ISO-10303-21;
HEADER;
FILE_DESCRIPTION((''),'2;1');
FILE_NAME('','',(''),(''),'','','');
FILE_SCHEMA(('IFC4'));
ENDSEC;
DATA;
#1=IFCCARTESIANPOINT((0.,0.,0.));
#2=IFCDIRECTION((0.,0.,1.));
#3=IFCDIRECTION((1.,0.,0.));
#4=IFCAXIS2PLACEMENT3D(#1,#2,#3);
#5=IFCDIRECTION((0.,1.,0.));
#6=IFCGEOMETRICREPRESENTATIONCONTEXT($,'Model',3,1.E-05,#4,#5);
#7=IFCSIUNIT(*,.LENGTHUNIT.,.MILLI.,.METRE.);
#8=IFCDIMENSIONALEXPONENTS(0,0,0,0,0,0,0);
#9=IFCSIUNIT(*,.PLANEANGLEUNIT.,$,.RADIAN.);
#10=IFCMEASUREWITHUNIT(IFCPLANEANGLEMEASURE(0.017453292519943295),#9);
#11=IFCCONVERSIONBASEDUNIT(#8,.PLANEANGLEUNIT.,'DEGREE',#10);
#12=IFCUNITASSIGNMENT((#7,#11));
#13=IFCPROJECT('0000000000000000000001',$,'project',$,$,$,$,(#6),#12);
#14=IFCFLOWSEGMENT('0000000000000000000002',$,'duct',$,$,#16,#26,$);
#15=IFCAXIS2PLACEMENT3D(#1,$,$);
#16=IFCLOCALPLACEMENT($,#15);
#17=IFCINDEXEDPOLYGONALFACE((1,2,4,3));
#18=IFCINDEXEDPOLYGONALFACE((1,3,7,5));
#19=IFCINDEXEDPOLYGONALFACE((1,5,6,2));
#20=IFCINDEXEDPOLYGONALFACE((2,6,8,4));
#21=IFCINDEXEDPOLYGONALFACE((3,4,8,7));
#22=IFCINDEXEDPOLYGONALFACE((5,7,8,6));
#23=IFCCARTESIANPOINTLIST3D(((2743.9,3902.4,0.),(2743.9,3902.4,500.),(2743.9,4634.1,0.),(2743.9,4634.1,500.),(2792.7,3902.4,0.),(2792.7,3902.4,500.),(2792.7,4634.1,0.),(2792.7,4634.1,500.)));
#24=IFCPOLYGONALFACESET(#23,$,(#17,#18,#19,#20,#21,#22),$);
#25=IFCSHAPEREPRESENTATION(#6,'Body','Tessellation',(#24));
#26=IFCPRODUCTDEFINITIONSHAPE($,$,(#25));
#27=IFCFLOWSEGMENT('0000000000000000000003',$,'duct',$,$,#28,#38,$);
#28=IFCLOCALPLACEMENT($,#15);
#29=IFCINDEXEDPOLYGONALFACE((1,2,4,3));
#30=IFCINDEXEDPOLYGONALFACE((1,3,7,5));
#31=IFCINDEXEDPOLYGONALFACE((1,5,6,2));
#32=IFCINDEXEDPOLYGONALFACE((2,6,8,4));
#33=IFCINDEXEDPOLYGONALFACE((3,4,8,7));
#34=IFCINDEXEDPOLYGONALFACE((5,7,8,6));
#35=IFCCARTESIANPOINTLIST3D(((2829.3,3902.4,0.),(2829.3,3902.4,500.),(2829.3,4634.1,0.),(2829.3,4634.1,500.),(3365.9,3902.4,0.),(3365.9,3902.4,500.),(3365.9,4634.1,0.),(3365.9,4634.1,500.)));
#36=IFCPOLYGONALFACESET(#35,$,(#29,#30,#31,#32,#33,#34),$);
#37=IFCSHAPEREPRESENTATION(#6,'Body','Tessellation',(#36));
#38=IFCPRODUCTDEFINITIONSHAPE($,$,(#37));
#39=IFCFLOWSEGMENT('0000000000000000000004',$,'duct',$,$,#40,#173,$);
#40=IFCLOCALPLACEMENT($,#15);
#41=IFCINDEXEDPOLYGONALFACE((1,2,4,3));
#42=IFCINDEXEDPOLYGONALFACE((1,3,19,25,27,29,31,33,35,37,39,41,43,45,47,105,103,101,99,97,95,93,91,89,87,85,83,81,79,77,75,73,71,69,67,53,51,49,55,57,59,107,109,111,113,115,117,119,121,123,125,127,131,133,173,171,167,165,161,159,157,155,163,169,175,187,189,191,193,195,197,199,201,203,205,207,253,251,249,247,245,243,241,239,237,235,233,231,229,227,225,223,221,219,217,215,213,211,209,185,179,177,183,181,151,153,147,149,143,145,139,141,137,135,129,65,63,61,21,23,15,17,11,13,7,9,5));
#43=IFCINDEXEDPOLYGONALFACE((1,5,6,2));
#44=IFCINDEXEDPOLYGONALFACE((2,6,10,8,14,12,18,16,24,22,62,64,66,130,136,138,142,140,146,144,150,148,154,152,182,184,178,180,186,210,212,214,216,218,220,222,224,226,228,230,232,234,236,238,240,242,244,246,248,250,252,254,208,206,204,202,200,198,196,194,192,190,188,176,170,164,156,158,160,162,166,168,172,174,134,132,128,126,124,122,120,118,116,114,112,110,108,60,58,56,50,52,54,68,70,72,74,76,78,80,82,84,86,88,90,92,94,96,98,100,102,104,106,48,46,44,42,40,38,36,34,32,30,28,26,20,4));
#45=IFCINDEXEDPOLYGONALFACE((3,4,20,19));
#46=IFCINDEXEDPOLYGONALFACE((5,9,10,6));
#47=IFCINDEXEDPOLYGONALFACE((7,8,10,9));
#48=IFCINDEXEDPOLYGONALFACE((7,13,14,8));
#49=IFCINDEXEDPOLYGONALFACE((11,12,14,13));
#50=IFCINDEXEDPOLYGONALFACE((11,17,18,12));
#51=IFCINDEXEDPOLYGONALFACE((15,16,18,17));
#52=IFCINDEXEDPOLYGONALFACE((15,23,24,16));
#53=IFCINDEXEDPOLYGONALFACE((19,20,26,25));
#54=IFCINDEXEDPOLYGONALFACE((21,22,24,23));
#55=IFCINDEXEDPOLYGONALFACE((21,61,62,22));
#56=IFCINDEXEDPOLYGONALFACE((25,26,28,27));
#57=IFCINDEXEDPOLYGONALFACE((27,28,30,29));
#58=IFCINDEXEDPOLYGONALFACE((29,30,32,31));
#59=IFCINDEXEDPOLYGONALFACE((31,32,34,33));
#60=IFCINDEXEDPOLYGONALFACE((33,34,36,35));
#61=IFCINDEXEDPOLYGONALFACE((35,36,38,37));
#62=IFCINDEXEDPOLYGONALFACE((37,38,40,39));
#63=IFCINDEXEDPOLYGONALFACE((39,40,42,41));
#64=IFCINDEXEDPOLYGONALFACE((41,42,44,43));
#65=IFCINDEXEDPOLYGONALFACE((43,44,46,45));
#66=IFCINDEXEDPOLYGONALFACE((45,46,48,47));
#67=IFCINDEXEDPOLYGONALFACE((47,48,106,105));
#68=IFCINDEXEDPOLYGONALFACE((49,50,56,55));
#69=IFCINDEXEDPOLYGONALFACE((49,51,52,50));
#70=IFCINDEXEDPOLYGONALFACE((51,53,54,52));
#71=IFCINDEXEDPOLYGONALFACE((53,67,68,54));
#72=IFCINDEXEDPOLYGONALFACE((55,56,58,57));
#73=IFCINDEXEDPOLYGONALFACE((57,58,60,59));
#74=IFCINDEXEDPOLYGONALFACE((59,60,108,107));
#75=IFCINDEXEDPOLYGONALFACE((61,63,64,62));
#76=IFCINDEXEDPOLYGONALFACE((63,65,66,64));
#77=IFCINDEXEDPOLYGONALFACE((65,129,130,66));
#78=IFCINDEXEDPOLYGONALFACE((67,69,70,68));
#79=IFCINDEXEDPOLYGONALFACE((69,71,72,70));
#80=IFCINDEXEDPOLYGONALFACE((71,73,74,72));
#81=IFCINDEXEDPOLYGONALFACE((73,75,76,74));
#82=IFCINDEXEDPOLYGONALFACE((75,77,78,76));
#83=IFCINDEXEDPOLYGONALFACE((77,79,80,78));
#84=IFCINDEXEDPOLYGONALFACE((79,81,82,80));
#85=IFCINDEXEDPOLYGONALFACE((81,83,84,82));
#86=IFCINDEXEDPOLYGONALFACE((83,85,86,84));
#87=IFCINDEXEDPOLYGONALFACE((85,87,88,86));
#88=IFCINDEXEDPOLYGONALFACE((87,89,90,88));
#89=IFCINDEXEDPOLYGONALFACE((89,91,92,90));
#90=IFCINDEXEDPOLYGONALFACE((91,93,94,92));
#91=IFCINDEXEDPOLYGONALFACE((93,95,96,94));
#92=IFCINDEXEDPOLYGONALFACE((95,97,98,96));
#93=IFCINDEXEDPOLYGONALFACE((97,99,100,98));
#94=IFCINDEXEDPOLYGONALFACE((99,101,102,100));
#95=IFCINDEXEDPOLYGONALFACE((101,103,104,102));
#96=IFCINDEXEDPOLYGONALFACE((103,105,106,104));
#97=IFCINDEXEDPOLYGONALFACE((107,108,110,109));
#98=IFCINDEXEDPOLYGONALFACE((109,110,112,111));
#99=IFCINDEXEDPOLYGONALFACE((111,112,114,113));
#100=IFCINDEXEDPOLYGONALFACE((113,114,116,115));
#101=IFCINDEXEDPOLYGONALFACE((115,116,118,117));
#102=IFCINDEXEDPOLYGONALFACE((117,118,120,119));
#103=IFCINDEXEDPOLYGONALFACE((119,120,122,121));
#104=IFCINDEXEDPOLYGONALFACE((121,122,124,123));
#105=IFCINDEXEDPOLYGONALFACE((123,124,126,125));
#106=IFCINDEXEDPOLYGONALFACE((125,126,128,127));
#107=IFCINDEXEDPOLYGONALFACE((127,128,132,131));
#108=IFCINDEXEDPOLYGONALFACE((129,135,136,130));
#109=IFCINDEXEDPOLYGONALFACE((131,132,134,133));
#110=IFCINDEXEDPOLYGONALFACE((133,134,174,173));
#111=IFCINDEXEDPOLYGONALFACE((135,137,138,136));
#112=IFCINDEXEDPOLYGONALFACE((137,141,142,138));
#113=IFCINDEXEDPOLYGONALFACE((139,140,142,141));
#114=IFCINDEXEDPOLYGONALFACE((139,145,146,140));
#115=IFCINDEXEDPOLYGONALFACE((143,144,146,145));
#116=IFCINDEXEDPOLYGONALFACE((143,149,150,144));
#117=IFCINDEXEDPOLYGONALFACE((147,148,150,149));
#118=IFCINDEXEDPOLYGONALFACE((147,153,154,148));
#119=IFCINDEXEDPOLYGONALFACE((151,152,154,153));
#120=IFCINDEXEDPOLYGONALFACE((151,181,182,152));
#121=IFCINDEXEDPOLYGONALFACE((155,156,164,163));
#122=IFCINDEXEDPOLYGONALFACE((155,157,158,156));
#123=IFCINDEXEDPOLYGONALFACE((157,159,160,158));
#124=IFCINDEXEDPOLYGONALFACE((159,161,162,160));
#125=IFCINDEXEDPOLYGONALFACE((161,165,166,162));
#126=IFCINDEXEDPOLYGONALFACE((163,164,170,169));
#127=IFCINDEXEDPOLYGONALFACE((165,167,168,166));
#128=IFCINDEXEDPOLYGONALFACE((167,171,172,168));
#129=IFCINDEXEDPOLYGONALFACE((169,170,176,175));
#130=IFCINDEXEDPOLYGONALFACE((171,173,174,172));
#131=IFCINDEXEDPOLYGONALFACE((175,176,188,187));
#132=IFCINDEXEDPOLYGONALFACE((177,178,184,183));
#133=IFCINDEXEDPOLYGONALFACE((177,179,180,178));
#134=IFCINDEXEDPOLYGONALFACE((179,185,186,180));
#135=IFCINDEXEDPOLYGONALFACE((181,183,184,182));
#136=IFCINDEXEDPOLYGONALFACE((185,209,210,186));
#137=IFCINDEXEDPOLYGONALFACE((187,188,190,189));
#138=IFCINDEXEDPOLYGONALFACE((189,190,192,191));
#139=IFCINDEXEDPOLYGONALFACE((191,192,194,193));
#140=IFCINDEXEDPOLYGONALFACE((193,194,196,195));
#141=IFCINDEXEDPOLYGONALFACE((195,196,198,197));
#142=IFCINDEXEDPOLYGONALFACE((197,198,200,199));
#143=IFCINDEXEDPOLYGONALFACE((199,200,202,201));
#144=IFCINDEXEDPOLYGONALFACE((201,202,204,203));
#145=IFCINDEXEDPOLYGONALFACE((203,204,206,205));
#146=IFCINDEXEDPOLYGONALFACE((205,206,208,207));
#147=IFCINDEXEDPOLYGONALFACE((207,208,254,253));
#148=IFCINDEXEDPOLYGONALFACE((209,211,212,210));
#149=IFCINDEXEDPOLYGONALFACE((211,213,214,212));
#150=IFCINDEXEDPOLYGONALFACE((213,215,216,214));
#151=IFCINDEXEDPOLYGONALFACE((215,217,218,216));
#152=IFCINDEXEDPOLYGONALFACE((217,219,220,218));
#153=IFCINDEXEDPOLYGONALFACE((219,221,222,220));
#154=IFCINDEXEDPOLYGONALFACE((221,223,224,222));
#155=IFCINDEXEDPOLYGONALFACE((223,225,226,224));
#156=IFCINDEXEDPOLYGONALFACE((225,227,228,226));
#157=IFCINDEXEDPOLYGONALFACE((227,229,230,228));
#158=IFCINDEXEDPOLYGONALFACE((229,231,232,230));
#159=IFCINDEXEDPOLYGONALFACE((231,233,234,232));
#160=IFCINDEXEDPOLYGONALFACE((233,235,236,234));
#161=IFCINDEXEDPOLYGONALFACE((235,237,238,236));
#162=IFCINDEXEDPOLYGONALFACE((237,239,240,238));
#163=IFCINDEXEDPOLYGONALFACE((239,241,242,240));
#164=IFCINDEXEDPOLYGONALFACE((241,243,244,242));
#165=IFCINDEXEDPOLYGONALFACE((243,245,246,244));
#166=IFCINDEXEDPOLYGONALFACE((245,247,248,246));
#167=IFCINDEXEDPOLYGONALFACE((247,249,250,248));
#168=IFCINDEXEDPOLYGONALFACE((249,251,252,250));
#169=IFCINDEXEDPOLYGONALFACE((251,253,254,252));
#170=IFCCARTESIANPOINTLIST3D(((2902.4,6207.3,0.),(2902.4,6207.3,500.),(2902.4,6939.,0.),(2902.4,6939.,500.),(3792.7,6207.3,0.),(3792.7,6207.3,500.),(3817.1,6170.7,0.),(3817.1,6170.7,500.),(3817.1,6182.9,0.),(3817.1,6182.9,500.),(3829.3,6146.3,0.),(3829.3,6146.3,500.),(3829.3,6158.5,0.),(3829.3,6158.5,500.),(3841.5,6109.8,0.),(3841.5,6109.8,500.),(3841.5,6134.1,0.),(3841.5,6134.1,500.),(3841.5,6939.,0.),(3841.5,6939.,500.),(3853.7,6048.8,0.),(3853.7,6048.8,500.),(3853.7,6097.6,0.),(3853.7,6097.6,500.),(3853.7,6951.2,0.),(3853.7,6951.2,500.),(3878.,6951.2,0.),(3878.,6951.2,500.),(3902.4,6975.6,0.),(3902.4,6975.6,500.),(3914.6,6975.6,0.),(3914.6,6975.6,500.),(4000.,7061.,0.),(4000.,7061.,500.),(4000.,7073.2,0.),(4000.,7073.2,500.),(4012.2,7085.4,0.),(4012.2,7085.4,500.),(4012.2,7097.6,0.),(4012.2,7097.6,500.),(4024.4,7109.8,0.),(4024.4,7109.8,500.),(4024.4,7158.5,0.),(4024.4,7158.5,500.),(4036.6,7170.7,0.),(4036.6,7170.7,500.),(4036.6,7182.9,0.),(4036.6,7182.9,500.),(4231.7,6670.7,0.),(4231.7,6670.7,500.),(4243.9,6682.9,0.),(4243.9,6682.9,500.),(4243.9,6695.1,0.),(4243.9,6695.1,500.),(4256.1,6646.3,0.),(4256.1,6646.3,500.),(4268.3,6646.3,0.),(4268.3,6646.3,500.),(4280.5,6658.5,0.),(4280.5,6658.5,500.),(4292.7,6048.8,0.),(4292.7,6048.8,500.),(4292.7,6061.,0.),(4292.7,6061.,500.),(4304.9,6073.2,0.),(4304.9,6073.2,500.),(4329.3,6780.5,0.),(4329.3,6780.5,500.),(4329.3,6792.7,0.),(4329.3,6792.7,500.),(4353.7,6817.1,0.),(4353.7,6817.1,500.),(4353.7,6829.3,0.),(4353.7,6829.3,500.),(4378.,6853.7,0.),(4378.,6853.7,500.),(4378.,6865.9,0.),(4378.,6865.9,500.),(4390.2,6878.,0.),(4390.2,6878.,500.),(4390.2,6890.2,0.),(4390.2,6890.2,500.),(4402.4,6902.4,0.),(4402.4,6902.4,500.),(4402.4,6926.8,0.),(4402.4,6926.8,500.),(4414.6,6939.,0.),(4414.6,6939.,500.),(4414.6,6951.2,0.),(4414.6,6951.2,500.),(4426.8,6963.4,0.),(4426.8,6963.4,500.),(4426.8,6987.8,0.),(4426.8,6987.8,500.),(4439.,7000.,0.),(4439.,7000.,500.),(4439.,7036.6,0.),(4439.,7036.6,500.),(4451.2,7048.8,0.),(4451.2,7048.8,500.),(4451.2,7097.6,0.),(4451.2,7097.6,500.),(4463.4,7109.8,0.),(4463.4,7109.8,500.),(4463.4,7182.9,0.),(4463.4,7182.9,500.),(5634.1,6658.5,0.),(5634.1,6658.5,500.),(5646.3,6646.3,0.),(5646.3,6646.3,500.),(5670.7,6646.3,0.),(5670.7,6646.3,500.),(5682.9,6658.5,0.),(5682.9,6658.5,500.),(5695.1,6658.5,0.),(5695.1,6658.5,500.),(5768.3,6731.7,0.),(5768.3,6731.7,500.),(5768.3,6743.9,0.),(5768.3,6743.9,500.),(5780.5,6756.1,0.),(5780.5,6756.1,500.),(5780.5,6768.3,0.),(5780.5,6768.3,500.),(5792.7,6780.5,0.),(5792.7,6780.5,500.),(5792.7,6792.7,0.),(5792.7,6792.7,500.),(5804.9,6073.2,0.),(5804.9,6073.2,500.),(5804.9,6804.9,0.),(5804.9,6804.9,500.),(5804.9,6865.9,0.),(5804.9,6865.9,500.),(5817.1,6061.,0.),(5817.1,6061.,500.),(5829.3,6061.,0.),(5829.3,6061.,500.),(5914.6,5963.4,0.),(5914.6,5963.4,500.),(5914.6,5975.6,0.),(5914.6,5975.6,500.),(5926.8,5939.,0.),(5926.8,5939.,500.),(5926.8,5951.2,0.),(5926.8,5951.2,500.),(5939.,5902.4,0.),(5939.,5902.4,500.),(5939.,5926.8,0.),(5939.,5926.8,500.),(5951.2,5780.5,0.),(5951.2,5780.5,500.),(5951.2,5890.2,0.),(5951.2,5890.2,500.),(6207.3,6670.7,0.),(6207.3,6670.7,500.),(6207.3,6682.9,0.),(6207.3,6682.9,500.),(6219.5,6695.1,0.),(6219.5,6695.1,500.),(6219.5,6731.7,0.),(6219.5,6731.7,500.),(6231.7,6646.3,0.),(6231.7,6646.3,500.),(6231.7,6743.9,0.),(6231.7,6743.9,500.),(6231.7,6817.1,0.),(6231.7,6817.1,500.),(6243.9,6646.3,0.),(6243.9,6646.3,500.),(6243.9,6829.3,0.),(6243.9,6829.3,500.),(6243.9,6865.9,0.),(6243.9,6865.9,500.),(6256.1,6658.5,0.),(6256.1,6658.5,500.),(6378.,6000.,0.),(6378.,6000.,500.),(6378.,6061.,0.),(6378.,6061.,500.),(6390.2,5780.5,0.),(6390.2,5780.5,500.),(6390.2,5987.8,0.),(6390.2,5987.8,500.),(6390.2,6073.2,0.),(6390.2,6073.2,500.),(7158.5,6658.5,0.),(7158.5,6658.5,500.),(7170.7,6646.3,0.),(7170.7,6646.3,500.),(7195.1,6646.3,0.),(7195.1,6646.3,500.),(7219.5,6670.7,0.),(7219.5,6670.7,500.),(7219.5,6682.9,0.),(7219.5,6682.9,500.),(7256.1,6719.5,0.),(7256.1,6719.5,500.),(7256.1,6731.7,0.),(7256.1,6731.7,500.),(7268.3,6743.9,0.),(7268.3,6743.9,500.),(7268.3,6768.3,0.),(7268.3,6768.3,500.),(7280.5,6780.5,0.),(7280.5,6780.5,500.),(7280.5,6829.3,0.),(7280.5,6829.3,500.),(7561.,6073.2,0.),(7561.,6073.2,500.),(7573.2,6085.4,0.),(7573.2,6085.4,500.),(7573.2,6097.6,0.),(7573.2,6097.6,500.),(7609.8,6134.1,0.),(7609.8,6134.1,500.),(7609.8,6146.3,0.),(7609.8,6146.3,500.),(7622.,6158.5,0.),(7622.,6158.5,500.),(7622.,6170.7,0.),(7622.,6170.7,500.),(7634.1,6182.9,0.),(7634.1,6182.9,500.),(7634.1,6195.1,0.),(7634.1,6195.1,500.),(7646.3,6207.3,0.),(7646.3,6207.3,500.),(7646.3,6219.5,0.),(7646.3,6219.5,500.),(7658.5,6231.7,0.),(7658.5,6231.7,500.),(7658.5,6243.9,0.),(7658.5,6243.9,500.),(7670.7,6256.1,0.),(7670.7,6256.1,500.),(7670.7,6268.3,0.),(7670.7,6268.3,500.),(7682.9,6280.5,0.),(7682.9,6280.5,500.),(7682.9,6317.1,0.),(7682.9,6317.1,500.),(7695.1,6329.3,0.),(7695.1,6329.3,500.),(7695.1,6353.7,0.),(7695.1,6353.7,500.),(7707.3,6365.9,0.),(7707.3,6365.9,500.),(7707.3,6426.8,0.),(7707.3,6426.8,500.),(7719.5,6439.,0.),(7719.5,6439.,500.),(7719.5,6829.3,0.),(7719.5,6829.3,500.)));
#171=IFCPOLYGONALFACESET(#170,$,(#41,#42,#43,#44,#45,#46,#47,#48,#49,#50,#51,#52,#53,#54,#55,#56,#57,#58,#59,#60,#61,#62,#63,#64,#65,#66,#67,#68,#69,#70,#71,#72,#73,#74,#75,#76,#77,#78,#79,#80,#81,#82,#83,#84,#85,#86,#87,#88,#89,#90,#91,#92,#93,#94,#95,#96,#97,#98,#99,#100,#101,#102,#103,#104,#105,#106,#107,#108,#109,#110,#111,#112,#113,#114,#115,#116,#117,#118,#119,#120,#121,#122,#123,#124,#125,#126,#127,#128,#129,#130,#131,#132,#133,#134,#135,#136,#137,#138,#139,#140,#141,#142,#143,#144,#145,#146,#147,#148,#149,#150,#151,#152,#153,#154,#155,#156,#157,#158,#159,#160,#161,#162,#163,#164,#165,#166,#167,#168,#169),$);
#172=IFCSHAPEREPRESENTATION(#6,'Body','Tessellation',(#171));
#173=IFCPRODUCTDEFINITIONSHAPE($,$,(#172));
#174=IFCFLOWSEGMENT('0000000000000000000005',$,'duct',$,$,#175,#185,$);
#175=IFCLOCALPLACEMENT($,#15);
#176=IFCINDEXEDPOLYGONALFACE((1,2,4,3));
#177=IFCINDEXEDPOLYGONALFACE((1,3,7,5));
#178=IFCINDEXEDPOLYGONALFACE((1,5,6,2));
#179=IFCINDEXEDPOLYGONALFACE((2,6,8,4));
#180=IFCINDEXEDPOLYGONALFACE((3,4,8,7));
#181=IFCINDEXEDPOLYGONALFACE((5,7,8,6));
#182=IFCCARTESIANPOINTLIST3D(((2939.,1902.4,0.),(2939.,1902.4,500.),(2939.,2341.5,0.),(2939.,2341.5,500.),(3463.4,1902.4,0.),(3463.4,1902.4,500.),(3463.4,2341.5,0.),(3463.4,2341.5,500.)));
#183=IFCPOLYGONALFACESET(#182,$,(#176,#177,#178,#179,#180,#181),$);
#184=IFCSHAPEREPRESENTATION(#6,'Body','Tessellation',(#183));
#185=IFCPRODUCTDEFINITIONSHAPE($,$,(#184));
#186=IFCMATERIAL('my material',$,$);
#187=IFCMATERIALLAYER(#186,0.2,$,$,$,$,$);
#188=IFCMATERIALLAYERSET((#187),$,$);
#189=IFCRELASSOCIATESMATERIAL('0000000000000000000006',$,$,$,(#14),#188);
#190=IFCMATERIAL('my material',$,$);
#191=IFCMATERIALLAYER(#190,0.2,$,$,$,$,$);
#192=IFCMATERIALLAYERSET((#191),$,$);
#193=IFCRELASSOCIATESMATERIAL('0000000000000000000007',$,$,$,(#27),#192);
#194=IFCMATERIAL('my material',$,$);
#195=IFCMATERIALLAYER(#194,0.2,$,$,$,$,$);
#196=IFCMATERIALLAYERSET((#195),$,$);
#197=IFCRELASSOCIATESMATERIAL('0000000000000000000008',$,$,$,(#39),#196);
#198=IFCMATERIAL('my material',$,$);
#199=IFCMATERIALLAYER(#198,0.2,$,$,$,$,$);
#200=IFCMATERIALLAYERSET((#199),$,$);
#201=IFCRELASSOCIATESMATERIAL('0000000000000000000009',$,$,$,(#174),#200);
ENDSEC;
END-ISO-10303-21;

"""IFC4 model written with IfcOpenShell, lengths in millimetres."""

from ifc_helpers import new_model, entity, si_unit, converted_unit, direction, origin_with_axes, place, context, project, polyline, outline, extrude, material, layer, layer_set, layer_usage, element, save


model = new_model("IFC4")

# Units and contexts
model_context = context("Model", 3, precision=1e-05, world=origin_with_axes(), true_north=direction((0.0, 1.0, 0.0)))
ifc_project = project(units=[si_unit("LENGTHUNIT", "METRE", prefix="MILLI"), converted_unit("PLANEANGLEUNIT", "DEGREE", entity("IfcPlaneAngleMeasure", 0.017453292519943295), si_unit("PLANEANGLEUNIT", "RADIAN"), dimensions=[0, 0, 0, 0, 0, 0, 0])], contexts=[model_context])

# Flow segments
ifc_material_1 = material(Name="my material")
ifc_layer_1 = layer(ifc_material_1, 0.2)
ifc_layer_set_1 = layer_set([ifc_layer_1])
ifc_layer_usage_1 = layer_usage(ifc_layer_set_1, "AXIS2", "POSITIVE", -0.1)
flow_segment_1_placement = place(None, origin_with_axes())
element("IfcFlowSegment", 1, at=flow_segment_1_placement, material=ifc_layer_usage_1, Name="duct", context=model_context, shape_type="SweptSolid", body=[
    extrude(outline(polyline([(2743.9, 3902.4), (2792.7, 3902.4), (2792.7, 4634.1), (2743.9, 4634.1), (2743.9, 3902.4)])), origin_with_axes(), (0.0, 0.0, 1.0), 500.0),
])
ifc_material_2 = material(Name="my material")
ifc_layer_2 = layer(ifc_material_2, 0.2)
ifc_layer_set_2 = layer_set([ifc_layer_2])
ifc_layer_usage_2 = layer_usage(ifc_layer_set_2, "AXIS2", "POSITIVE", -0.1)
flow_segment_2_placement = place(None, origin_with_axes())
element("IfcFlowSegment", 2, at=flow_segment_2_placement, material=ifc_layer_usage_2, Name="duct", context=model_context, shape_type="SweptSolid", body=[
    extrude(outline(polyline([(2829.3, 3902.4), (3365.9, 3902.4), (3365.9, 4634.1), (2829.3, 4634.1), (2829.3, 3902.4)])), origin_with_axes(), (0.0, 0.0, 1.0), 500.0),
])
ifc_material_3 = material(Name="my material")
ifc_layer_3 = layer(ifc_material_3, 0.2)
ifc_layer_set_3 = layer_set([ifc_layer_3])
ifc_layer_usage_3 = layer_usage(ifc_layer_set_3, "AXIS2", "POSITIVE", -0.1)
flow_segment_3_placement = place(None, origin_with_axes())
element("IfcFlowSegment", 3, at=flow_segment_3_placement, material=ifc_layer_usage_3, Name="duct", context=model_context, shape_type="SweptSolid", body=[
    extrude(outline(polyline([(2902.4, 6207.3), (3792.7, 6207.3), (3817.1, 6182.9), (3817.1, 6170.7), (3829.3, 6158.5), (3829.3, 6146.3), (3841.5, 6134.1), (3841.5, 6109.8), (3853.7, 6097.6), (3853.7, 6048.8), (4292.7, 6048.8), (4292.7, 6061.0), (4304.9, 6073.2), (5804.9, 6073.2), (5817.1, 6061.0), (5829.3, 6061.0), (5914.6, 5975.6), (5914.6, 5963.4), (5926.8, 5951.2), (5926.8, 5939.0), (5939.0, 5926.8), (5939.0, 5902.4), (5951.2, 5890.2), (5951.2, 5780.5), (6390.2, 5780.5), (6390.2, 5987.8), (6378.0, 6000.0), (6378.0, 6061.0), (6390.2, 6073.2), (7561.0, 6073.2), (7573.2, 6085.4), (7573.2, 6097.6), (7609.8, 6134.1), (7609.8, 6146.3), (7622.0, 6158.5), (7622.0, 6170.7), (7634.1, 6182.9), (7634.1, 6195.1), (7646.3, 6207.3), (7646.3, 6219.5), (7658.5, 6231.7), (7658.5, 6243.9), (7670.7, 6256.1), (7670.7, 6268.3), (7682.9, 6280.5), (7682.9, 6317.1), (7695.1, 6329.3), (7695.1, 6353.7), (7707.3, 6365.9), (7707.3, 6426.8), (7719.5, 6439.0), (7719.5, 6829.3), (7280.5, 6829.3), (7280.5, 6780.5), (7268.3, 6768.3), (7268.3, 6743.9), (7256.1, 6731.7), (7256.1, 6719.5), (7219.5, 6682.9), (7219.5, 6670.7), (7195.1, 6646.3), (7170.7, 6646.3), (7158.5, 6658.5), (6256.1, 6658.5), (6243.9, 6646.3), (6231.7, 6646.3), (6207.3, 6670.7), (6207.3, 6682.9), (6219.5, 6695.1), (6219.5, 6731.7), (6231.7, 6743.9), (6231.7, 6817.1), (6243.9, 6829.3), (6243.9, 6865.9), (5804.9, 6865.9), (5804.9, 6804.9), (5792.7, 6792.7), (5792.7, 6780.5), (5780.5, 6768.3), (5780.5, 6756.1), (5768.3, 6743.9), (5768.3, 6731.7), (5695.1, 6658.5), (5682.9, 6658.5), (5670.7, 6646.3), (5646.3, 6646.3), (5634.1, 6658.5), (4280.5, 6658.5), (4268.3, 6646.3), (4256.1, 6646.3), (4231.7, 6670.7), (4243.9, 6682.9), (4243.9, 6695.1), (4329.3, 6780.5), (4329.3, 6792.7), (4353.7, 6817.1), (4353.7, 6829.3), (4378.0, 6853.7), (4378.0, 6865.9), (4390.2, 6878.0), (4390.2, 6890.2), (4402.4, 6902.4), (4402.4, 6926.8), (4414.6, 6939.0), (4414.6, 6951.2), (4426.8, 6963.4), (4426.8, 6987.8), (4439.0, 7000.0), (4439.0, 7036.6), (4451.2, 7048.8), (4451.2, 7097.6), (4463.4, 7109.8), (4463.4, 7182.9), (4036.6, 7182.9), (4036.6, 7170.7), (4024.4, 7158.5), (4024.4, 7109.8), (4012.2, 7097.6), (4012.2, 7085.4), (4000.0, 7073.2), (4000.0, 7061.0), (3914.6, 6975.6), (3902.4, 6975.6), (3878.0, 6951.2), (3853.7, 6951.2), (3841.5, 6939.0), (2902.4, 6939.0), (2902.4, 6207.3)])), origin_with_axes(), (0.0, 0.0, 1.0), 500.0),
])
ifc_material_4 = material(Name="my material")
ifc_layer_4 = layer(ifc_material_4, 0.2)
ifc_layer_set_4 = layer_set([ifc_layer_4])
ifc_layer_usage_4 = layer_usage(ifc_layer_set_4, "AXIS2", "POSITIVE", -0.1)
flow_segment_4_placement = place(None, origin_with_axes())
element("IfcFlowSegment", 4, at=flow_segment_4_placement, material=ifc_layer_usage_4, Name="duct", context=model_context, shape_type="SweptSolid", body=[
    extrude(outline(polyline([(2939.0, 1902.4), (3463.4, 1902.4), (3463.4, 2341.5), (2939.0, 2341.5), (2939.0, 1902.4)])), origin_with_axes(), (0.0, 0.0, 1.0), 500.0),
])

save(model, "model.ifc")
